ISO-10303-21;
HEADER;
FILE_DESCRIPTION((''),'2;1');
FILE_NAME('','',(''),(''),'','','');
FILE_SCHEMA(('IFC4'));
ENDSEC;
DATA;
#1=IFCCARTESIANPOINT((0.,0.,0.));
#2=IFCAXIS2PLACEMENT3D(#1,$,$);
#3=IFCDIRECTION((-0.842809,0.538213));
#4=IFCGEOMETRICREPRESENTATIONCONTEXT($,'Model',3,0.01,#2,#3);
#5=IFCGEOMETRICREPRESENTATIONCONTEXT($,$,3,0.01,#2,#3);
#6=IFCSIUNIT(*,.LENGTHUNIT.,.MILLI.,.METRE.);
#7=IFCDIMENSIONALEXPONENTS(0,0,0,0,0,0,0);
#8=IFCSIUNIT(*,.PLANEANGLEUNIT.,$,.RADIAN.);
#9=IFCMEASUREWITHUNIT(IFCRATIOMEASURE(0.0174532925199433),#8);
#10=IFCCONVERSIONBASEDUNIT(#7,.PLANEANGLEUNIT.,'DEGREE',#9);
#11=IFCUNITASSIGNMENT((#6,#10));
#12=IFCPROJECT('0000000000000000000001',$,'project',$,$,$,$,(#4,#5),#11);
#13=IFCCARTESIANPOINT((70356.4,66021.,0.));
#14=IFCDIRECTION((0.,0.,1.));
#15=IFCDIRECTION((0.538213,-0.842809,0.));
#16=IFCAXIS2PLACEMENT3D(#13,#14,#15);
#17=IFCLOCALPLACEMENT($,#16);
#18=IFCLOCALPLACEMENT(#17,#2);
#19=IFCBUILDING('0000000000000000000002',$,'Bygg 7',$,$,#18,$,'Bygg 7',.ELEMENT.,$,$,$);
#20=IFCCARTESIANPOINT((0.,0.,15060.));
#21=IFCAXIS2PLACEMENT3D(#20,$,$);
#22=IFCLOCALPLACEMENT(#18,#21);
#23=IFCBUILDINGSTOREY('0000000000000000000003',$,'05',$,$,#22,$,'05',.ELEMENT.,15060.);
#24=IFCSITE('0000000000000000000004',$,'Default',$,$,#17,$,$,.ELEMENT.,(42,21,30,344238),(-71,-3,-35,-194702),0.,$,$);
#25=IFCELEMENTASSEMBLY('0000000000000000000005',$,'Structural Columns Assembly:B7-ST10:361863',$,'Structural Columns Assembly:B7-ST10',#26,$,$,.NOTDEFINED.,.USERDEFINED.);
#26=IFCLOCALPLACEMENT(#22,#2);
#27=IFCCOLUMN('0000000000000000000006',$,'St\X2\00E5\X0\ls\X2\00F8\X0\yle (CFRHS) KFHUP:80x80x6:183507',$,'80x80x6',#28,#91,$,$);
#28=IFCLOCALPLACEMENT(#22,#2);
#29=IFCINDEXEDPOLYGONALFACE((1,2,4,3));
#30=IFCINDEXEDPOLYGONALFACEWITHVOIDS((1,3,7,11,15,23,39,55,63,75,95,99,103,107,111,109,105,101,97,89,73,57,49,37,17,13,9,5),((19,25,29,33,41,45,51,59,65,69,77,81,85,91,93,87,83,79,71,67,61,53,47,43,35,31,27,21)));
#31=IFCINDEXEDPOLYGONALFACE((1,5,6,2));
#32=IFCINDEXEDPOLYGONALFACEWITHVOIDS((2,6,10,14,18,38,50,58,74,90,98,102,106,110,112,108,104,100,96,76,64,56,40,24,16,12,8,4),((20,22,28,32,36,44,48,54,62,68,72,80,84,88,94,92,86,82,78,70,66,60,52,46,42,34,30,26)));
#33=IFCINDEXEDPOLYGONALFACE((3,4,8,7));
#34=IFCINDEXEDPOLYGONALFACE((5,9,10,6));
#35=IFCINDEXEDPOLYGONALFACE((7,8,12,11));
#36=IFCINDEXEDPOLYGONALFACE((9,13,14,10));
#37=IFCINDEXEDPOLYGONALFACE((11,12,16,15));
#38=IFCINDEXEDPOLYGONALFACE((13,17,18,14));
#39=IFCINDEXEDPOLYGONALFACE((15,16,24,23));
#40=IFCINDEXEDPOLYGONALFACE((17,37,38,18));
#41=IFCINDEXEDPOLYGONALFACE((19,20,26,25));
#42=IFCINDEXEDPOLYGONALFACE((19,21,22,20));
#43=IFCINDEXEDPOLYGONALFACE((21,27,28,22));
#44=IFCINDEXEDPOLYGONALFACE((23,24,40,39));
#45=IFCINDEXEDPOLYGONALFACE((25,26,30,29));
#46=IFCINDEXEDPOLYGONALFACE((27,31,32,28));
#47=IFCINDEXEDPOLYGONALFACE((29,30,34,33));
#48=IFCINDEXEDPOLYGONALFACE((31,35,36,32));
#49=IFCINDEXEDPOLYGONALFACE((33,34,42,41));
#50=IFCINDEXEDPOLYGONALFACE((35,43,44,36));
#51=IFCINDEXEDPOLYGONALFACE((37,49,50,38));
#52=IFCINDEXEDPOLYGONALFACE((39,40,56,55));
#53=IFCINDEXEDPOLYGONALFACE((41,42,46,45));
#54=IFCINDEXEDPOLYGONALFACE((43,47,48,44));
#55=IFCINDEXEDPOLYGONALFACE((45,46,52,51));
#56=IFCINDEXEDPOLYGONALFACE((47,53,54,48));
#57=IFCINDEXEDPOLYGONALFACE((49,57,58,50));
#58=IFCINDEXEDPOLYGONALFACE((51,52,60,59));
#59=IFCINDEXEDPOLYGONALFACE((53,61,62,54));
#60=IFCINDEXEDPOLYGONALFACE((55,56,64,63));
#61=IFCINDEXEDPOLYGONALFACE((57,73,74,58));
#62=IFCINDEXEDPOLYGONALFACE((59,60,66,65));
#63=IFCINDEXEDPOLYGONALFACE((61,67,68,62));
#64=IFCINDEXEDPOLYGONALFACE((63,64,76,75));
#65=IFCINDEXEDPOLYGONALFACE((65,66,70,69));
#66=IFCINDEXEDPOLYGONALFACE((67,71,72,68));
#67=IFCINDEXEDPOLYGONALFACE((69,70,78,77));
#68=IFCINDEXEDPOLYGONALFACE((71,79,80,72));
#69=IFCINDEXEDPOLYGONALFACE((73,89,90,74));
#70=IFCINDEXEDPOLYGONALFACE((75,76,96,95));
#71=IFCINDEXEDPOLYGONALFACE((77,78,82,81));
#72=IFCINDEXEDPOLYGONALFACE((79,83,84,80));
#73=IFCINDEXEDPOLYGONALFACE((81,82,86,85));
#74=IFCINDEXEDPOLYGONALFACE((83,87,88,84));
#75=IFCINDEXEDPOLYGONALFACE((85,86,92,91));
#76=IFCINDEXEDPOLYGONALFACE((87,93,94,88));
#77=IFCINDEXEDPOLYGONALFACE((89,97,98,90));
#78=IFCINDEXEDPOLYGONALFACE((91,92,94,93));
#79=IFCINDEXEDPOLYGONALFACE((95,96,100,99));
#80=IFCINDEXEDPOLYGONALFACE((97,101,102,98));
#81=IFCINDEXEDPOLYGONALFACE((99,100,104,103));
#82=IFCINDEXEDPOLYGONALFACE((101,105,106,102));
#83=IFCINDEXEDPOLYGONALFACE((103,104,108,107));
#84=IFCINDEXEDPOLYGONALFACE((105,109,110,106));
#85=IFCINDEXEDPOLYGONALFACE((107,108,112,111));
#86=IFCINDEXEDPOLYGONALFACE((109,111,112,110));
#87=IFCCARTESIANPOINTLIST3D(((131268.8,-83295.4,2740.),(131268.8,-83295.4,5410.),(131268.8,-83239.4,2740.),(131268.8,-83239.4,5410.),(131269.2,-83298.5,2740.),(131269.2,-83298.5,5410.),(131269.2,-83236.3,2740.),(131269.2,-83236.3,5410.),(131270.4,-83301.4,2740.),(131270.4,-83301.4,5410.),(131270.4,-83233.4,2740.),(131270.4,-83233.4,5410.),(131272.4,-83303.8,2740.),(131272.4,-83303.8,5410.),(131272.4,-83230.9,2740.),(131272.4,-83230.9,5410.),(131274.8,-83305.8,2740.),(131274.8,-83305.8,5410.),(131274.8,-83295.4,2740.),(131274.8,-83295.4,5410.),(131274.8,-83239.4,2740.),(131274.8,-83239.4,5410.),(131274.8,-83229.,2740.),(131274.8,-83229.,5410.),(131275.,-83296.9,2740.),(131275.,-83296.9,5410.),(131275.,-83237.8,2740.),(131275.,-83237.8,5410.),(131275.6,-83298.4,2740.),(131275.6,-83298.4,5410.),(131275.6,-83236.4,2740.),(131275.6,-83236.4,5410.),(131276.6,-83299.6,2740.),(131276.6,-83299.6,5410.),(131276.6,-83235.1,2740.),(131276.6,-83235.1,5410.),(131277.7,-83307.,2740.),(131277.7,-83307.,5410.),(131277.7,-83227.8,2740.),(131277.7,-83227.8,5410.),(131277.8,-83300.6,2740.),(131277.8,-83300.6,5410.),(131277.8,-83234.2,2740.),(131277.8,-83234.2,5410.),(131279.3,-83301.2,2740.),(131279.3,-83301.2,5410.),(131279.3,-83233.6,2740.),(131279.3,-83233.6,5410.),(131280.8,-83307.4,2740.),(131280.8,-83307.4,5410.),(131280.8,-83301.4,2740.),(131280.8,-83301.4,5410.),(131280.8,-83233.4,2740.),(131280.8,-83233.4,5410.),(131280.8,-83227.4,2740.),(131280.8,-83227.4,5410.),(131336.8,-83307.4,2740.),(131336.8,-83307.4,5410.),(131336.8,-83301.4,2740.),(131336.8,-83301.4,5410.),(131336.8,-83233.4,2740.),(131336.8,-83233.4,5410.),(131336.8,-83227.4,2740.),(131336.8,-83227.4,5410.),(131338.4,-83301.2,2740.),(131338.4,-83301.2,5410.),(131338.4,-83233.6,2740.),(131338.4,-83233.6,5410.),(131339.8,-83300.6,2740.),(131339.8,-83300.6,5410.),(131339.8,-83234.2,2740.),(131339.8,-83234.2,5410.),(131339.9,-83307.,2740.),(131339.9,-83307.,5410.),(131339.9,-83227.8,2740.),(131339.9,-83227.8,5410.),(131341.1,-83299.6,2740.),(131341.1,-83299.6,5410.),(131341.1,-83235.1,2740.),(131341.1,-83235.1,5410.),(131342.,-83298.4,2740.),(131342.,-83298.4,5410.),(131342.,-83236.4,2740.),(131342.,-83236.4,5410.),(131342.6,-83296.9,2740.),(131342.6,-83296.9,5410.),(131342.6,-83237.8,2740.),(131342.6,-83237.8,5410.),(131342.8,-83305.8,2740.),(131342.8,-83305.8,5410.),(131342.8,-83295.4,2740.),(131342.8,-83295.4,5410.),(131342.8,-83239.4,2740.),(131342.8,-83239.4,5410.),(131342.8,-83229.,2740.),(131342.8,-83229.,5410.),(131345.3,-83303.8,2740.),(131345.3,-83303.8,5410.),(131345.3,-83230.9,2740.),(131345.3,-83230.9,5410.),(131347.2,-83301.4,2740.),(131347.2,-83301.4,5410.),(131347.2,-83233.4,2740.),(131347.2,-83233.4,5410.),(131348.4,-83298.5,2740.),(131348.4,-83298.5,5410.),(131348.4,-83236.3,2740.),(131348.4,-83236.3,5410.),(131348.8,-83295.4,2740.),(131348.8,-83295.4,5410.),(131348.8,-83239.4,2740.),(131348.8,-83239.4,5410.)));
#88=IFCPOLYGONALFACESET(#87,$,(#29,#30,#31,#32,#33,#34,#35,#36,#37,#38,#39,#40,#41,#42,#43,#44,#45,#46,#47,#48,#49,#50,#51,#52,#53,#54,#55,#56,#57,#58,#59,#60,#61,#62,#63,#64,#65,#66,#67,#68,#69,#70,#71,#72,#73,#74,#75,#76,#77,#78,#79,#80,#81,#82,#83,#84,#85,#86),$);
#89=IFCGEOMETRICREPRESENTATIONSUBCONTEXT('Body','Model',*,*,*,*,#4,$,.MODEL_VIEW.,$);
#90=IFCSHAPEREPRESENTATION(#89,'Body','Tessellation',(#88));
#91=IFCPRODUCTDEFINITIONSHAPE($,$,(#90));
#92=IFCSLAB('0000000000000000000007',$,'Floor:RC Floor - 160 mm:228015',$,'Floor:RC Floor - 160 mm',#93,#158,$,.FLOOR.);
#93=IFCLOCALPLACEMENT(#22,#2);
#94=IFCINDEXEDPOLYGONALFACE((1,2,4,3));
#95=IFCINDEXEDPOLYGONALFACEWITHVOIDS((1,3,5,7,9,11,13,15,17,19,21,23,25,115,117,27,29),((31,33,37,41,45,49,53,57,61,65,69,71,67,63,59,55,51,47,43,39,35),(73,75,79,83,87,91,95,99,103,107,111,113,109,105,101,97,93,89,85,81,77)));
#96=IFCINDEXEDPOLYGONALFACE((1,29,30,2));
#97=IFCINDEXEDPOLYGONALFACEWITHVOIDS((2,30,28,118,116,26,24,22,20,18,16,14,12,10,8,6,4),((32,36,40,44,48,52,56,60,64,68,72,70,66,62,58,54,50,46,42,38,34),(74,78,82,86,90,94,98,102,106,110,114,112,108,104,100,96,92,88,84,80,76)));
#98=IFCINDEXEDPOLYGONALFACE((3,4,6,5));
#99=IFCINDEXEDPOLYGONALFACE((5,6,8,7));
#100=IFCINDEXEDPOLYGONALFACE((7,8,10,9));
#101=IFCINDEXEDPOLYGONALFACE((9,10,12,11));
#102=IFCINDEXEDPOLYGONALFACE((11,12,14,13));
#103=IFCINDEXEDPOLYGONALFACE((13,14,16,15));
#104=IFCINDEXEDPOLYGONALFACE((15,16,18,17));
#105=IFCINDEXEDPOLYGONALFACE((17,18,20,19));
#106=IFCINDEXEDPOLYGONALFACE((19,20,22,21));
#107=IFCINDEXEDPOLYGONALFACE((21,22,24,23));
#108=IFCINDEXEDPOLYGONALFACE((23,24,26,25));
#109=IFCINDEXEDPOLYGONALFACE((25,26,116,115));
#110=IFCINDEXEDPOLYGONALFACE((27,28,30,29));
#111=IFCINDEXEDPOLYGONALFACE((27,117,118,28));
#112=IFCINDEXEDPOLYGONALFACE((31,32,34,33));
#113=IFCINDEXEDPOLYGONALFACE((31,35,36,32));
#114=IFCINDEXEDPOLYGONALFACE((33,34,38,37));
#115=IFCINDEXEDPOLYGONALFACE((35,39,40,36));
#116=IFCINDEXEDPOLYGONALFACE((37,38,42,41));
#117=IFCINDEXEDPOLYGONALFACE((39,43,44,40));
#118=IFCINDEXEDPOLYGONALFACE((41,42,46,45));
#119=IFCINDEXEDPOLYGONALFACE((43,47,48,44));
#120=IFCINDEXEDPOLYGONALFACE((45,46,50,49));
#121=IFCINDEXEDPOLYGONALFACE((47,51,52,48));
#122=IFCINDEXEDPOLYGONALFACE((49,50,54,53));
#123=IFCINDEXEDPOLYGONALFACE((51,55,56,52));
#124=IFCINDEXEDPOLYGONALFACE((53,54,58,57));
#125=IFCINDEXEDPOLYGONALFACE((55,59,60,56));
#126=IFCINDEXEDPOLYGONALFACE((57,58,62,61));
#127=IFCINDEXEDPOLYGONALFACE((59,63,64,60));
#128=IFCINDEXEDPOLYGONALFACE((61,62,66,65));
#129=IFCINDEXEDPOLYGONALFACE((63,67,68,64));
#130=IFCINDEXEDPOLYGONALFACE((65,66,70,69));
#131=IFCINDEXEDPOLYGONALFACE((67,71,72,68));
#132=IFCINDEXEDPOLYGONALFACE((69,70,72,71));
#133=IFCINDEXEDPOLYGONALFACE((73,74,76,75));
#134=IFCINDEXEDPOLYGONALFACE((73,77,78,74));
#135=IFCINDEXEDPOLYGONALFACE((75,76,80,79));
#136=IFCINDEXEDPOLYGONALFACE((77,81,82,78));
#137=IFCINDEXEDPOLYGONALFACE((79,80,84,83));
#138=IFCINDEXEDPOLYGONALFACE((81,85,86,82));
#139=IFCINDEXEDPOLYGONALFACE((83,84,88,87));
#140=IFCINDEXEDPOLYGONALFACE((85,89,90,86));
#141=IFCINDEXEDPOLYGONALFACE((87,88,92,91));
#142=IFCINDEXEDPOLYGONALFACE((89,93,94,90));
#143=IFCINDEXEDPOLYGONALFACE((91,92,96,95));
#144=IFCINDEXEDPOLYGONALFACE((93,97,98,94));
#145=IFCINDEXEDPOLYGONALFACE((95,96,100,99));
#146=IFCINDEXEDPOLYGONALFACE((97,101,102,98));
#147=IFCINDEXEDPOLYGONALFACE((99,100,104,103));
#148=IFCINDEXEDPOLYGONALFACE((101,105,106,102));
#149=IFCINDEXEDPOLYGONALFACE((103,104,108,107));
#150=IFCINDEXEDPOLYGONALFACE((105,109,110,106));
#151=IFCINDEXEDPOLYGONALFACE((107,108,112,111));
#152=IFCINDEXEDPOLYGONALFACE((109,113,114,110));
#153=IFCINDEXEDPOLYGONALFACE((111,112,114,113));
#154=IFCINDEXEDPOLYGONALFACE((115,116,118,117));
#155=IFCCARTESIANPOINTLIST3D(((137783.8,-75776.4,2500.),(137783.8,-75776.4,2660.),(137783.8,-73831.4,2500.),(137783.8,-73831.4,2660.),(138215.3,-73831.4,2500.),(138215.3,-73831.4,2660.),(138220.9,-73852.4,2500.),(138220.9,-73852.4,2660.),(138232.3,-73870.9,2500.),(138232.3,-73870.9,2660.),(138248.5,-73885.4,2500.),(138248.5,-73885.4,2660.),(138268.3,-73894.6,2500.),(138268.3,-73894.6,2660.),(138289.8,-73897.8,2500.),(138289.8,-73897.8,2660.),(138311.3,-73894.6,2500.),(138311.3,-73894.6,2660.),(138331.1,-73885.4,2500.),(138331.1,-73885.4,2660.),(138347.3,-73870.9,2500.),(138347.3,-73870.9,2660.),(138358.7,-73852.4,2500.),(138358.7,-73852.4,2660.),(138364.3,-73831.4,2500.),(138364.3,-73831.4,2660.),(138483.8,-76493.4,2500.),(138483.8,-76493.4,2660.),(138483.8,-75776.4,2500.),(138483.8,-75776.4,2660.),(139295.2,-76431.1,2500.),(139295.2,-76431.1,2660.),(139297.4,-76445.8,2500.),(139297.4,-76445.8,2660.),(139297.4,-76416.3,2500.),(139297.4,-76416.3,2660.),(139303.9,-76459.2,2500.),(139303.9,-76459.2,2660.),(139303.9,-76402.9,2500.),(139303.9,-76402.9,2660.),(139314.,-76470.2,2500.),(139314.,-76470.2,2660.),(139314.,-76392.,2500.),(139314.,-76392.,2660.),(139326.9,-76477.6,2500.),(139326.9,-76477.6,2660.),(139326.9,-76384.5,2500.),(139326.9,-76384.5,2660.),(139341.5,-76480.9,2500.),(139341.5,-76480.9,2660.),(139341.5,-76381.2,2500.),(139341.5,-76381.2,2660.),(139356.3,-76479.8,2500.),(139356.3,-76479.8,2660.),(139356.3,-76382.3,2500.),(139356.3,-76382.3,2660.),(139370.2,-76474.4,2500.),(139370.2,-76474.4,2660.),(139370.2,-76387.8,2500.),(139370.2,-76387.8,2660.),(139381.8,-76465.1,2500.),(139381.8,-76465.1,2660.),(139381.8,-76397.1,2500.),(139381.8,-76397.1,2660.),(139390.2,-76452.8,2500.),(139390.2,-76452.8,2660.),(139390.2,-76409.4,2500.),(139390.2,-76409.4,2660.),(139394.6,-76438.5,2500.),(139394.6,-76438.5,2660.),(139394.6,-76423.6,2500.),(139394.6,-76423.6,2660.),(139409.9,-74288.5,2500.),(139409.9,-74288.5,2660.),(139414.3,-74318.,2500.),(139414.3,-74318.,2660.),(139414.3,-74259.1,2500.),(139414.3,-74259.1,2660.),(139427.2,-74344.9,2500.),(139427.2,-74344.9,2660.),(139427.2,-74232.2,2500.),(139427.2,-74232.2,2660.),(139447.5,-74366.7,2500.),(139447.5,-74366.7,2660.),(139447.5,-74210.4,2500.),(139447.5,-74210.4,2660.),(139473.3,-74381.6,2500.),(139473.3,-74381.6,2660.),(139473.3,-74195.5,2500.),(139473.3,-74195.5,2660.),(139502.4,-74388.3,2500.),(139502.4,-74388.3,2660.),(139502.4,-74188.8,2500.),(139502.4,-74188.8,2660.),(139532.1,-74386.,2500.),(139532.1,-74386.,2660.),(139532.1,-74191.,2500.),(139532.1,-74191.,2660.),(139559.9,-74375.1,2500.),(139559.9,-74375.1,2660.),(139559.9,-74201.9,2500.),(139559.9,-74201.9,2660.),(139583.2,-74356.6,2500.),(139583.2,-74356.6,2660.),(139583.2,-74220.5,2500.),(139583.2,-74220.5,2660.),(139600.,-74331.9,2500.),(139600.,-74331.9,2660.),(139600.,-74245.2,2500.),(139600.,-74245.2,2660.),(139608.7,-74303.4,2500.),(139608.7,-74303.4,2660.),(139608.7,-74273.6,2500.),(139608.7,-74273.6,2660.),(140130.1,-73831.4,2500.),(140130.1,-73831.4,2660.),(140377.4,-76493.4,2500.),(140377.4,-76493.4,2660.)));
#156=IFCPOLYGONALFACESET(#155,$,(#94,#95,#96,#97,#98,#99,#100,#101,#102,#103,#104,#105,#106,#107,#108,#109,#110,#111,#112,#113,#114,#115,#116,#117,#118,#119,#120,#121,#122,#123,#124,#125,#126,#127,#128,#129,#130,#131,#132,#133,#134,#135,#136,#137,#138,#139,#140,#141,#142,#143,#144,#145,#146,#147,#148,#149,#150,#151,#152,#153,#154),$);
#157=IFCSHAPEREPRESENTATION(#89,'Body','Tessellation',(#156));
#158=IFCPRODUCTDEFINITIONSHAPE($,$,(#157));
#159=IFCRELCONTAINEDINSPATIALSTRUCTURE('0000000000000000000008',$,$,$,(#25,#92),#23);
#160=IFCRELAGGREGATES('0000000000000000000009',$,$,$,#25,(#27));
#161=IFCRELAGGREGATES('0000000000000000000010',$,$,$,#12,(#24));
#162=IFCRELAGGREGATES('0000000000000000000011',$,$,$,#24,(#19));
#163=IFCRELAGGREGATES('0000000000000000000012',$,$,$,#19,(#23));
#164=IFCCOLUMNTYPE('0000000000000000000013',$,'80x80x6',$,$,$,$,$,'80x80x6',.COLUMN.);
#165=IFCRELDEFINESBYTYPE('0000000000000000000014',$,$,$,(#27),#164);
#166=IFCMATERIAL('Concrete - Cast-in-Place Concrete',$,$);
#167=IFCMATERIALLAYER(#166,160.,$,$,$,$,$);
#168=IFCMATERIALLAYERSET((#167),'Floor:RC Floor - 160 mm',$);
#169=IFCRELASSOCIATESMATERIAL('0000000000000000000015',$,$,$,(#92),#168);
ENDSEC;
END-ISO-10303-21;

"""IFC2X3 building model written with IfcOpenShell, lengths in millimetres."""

from ifc_helpers import new_model, entity, si_unit, converted_unit, direction, frame, frame_2d, origin, place, context, subcontext, project, spatial, polyline, circle_curve, parameter, trimmed, segment, composite_curve, circle, outline, extrude, source, transform, mapped, material, layer, layer_set, layer_usage, type_object, type_shapes, element, aggregate, save


model = new_model("IFC2X3")

# Units and contexts
model_context = context("Model", 3, precision=0.01, world=origin(), true_north=direction((-0.842809, 0.538213)))
context_of_model = context(None, 3, precision=0.01, world=origin(), true_north=direction((-0.842809, 0.538213)))
body_context = subcontext(model_context, "Body", "Model", "MODEL_VIEW")
ifc_project = project(units=[si_unit("LENGTHUNIT", "METRE", prefix="MILLI"), converted_unit("PLANEANGLEUNIT", "DEGREE", entity("IfcRatioMeasure", 0.0174532925199433), si_unit("PLANEANGLEUNIT", "RADIAN"), dimensions=[0, 0, 0, 0, 0, 0, 0])], contexts=[model_context, context_of_model])

# Site, building, storey
site_placement = place(None, frame((70356.4, 66021.0, 0.0), z_axis=(0.0, 0.0, 1.0), x_axis=(0.538213, -0.842809, 0.0)))
site = spatial("IfcSite", under=ifc_project, at=site_placement, Name="Default", CompositionType="ELEMENT", RefLatitude=(42, 21, 30, 344238), RefLongitude=(-71, -3, -35, -194702), RefElevation=0.0)
building_placement = place(site_placement, origin())
building = spatial("IfcBuilding", under=site, at=building_placement, Name="Bygg 7", LongName="Bygg 7", CompositionType="ELEMENT")
storey_placement = place(building_placement, frame((0.0, 0.0, 15060.0)))
storey = spatial("IfcBuildingStorey", under=building, at=storey_placement, Name="05", LongName="05", CompositionType="ELEMENT", Elevation=15060.0)

# Element assembly, column
assembly_1_placement = place(storey_placement, origin())
assembly_1 = element("IfcElementAssembly", 1, at=assembly_1_placement, inside=storey, Name="Structural Columns Assembly:B7-ST10:361863", ObjectType="Structural Columns Assembly:B7-ST10", AssemblyPlace="NOTDEFINED", PredefinedType="USERDEFINED")
column_type_1 = type_object("IfcColumnType", Name="80x80x6", ElementType="80x80x6", PredefinedType="COLUMN")
shared_shape_1 = source(origin(), body_context, "Body", "SweptSolid", [
    extrude(outline(composite_curve([segment(trimmed(circle_curve(frame_2d((-28.0, 28.0), x_axis=(1.0, 0.0)), 12.0), [parameter(90.0)], [parameter(180.0)], True, "PARAMETER"), True, "CONTINUOUS"), segment(polyline([(-40.0, 28.0), (-40.0, -28.0)]), True, "CONTINUOUS"), segment(trimmed(circle_curve(frame_2d((-28.0, -28.0), x_axis=(1.0, 0.0)), 12.0), [parameter(180.0)], [parameter(270.0)], True, "PARAMETER"), True, "CONTINUOUS"), segment(polyline([(-28.0, -40.0), (28.0, -40.0)]), True, "CONTINUOUS"), segment(trimmed(circle_curve(frame_2d((28.0, -28.0), x_axis=(1.0, 0.0)), 12.0), [parameter(270.0)], [parameter(0.0)], True, "PARAMETER"), True, "CONTINUOUS"), segment(polyline([(40.0, -28.0), (40.0, 28.0)]), True, "CONTINUOUS"), segment(trimmed(circle_curve(frame_2d((28.0, 28.0), x_axis=(1.0, 0.0)), 12.0), [parameter(0.0)], [parameter(90.0)], True, "PARAMETER"), True, "CONTINUOUS"), segment(polyline([(28.0, 40.0), (-28.0, 40.0)]), True, "CONTINUOUS")], self_intersect=False), holes=[composite_curve([segment(polyline([(-28.0, 34.0), (28.0, 34.0)]), True, "CONTINUOUS"), segment(trimmed(circle_curve(frame_2d((28.0, 28.0), x_axis=(1.0, 0.0)), 6.0), [parameter(360.0)], [parameter(90.0)], True, "PARAMETER"), False, "CONTINUOUS"), segment(polyline([(34.0, 28.0), (34.0, -28.0)]), True, "CONTINUOUS"), segment(trimmed(circle_curve(frame_2d((28.0, -28.0), x_axis=(1.0, 0.0)), 6.0), [parameter(270.0)], [parameter(360.0)], True, "PARAMETER"), False, "CONTINUOUS"), segment(polyline([(28.0, -34.0), (-28.0, -34.0)]), True, "CONTINUOUS"), segment(trimmed(circle_curve(frame_2d((-28.0, -28.0), x_axis=(1.0, 0.0)), 6.0), [parameter(180.0)], [parameter(270.0)], True, "PARAMETER"), False, "CONTINUOUS"), segment(polyline([(-34.0, -28.0), (-34.0, 28.0)]), True, "CONTINUOUS"), segment(trimmed(circle_curve(frame_2d((-28.0, 28.0), x_axis=(1.0, 0.0)), 6.0), [parameter(90.0)], [parameter(180.0)], True, "PARAMETER"), False, "CONTINUOUS")], self_intersect=False)]), frame((41.6, 41.6, 0.0), z_axis=(0.0, 0.0, 1.0), x_axis=(0.0, -1.0, 0.0)), (0.0, 0.0, 1.0), 2670.0),
])
type_shapes(column_type_1, [shared_shape_1])
column_1_placement = place(assembly_1_placement, frame((131267.2, -83309.0, 2740.0)))
column_1 = element("IfcColumn", 2, at=column_1_placement, type_object=column_type_1, Name="Stålsøyle (CFRHS) KFHUP:80x80x6:183507", ObjectType="80x80x6", context=body_context, shape_type="MappedRepresentation", body=[
    mapped(shared_shape_1, transform((0.0, 0.0, 0.0), scale=1.0)),
])
aggregate(assembly_1, [column_1])

# Slab, openings
ifc_material_1 = material(Name="Concrete - Cast-in-Place Concrete")
ifc_layer_1 = layer(ifc_material_1, 160.0)
ifc_layer_set_1 = layer_set([ifc_layer_1], Name="Floor:RC Floor - 160 mm")
ifc_layer_usage_1 = layer_usage(ifc_layer_set_1, "AXIS3", "POSITIVE", 0.0)
slab_1_placement = place(storey_placement, frame((137783.8, -76493.4, 2500.0)))
slab_1 = element("IfcSlab", 3, at=slab_1_placement, inside=storey, material=ifc_layer_usage_1, Name="Floor:RC Floor - 160 mm:228015", ObjectType="Floor:RC Floor - 160 mm", PredefinedType="FLOOR", context=body_context, shape_type="SweptSolid", body=[
    extrude(outline(polyline([(1296.8, 1331.0), (-1049.4, 1331.0), (-1296.8, -1331.0), (596.8, -1331.0), (596.8, -614.0), (1296.8, -614.0), (1296.8, 1331.0)])), frame((1296.8, 1331.0, 160.0), z_axis=(0.0, 0.0, -1.0), x_axis=(-1.0, 0.0, 0.0)), (0.0, 0.0, 1.0), 160.0),
])
opening_1_placement = place(storey_placement, frame((137783.8, -76493.4, 2500.0)))
element("IfcOpeningElement", 4, at=opening_1_placement, cuts=slab_1, ObjectType="Opening", context=body_context, shape_type="SweptSolid", body=[
    extrude(circle(Radius=50.0, at=frame_2d((-264.6, -1268.7), x_axis=(1.0, 0.0))), frame((1296.8, 1331.0, 160.0), z_axis=(0.0, 0.0, -1.0), x_axis=(-1.0, 0.0, 0.0)), (0.0, 0.0, 1.0), 160.0),
])
opening_2_placement = place(storey_placement, frame((137783.8, -76493.4, 2500.0)))
element("IfcOpeningElement", 5, at=opening_2_placement, cuts=slab_1, ObjectType="Opening", context=body_context, shape_type="SweptSolid", body=[
    extrude(circle(Radius=100.0, at=frame_2d((-429.2, 873.8), x_axis=(1.0, 0.0))), frame((1296.8, 1331.0, 160.0), z_axis=(0.0, 0.0, -1.0), x_axis=(-1.0, 0.0, 0.0)), (0.0, 0.0, 1.0), 160.0),
])
opening_3_placement = place(storey_placement, frame((137783.8, -76493.4, 2500.0)))
element("IfcOpeningElement", 6, at=opening_3_placement, cuts=slab_1, ObjectType="Opening", context=body_context, shape_type="SweptSolid", body=[
    extrude(circle(Radius=75.0, at=frame_2d((790.8, 1339.6), x_axis=(1.0, 0.0))), frame((1296.8, 1331.0, 160.0), z_axis=(0.0, 0.0, -1.0), x_axis=(-1.0, 0.0, 0.0)), (0.0, 0.0, 1.0), 160.0),
])

save(model, "model.ifc")
